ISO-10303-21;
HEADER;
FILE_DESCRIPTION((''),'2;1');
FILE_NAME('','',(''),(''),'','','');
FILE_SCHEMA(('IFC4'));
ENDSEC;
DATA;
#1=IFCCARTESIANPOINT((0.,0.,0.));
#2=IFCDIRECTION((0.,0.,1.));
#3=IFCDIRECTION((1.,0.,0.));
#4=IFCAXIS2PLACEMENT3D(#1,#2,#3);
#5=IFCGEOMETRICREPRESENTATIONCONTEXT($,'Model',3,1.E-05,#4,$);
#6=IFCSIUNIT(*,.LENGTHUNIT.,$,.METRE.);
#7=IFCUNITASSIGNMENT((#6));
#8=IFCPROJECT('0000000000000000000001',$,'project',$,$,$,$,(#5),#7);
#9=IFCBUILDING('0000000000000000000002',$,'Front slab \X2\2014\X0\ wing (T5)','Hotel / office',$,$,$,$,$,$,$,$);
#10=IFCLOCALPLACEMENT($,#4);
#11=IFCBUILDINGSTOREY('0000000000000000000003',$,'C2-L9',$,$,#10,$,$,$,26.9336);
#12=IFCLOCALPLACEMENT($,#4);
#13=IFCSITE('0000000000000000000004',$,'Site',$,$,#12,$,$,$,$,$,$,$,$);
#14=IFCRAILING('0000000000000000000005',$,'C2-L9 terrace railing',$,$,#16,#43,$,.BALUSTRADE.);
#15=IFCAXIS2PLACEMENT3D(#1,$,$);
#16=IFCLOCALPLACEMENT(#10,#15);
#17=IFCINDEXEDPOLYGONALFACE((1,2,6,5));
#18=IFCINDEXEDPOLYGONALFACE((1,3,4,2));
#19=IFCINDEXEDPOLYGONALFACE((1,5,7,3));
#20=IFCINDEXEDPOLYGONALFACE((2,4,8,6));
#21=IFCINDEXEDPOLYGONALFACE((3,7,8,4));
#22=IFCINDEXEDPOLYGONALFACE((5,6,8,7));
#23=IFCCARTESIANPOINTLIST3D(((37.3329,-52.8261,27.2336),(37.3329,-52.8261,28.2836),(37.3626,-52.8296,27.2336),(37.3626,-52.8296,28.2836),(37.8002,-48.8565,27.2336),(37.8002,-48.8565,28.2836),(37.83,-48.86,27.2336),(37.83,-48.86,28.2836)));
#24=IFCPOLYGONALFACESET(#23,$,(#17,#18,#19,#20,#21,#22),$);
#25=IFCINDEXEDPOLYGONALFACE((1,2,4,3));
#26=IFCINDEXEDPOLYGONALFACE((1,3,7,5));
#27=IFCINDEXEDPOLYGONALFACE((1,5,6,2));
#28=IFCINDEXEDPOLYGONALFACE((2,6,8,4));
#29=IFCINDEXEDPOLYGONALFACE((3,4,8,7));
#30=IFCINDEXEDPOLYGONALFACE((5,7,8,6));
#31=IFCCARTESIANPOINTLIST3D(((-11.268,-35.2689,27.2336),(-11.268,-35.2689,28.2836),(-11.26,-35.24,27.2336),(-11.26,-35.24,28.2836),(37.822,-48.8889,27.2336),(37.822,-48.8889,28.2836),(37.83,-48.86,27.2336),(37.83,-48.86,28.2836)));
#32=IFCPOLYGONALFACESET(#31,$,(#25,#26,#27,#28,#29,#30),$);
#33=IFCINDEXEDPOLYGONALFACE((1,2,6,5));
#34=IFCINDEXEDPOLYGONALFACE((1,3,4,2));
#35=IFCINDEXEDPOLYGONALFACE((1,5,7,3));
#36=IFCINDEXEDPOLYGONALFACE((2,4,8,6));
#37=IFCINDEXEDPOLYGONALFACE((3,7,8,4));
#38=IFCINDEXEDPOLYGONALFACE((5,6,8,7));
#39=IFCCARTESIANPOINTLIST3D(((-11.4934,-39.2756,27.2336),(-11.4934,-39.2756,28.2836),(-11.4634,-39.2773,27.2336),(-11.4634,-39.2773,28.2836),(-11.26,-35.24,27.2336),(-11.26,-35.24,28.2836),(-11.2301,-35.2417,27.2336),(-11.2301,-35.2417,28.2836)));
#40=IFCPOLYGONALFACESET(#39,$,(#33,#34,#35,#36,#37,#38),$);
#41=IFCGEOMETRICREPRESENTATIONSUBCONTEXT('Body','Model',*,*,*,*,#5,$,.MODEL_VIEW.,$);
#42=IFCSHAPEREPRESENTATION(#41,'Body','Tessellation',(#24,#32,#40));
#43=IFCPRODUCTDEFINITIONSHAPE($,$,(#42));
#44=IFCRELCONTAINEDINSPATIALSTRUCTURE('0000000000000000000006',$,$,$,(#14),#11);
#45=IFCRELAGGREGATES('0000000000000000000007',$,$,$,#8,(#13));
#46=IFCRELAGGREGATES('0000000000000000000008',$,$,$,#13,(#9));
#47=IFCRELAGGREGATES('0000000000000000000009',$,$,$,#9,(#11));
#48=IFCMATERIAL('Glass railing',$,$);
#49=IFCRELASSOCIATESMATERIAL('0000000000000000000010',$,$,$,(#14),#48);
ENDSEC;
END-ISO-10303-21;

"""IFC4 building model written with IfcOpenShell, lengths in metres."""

from ifc_helpers import new_model, si_unit, frame, origin_with_axes, place, context, subcontext, project, spatial, polyline, outline, extrude, material, element, save


model = new_model("IFC4")

# Units and contexts
model_context = context("Model", 3, precision=1e-05, world=origin_with_axes())
body_context = subcontext(model_context, "Body", "Model", "MODEL_VIEW")
ifc_project = project(units=[si_unit("LENGTHUNIT", "METRE")], contexts=[model_context])

# Site, building, storey
site_placement = place(None, origin_with_axes())
site = spatial("IfcSite", under=ifc_project, at=site_placement, Name="Site")
building = spatial("IfcBuilding", under=site, Name="Front slab — wing (T5)", Description="Hotel / office")
storey_placement = place(None, origin_with_axes())
storey = spatial("IfcBuildingStorey", under=building, at=storey_placement, Name="C2-L9", Elevation=26.9336)

# Railing
ifc_material = material(Name="Glass railing")
railing_placement = place(storey_placement, origin_with_axes())
element("IfcRailing", 1, at=railing_placement, inside=storey, material=ifc_material, Name="C2-L9 terrace railing", PredefinedType="BALUSTRADE", context=body_context, shape_type="SweptSolid", body=[
    extrude(outline(polyline([(37.3626, -52.8296), (37.83, -48.86), (37.8002, -48.8565), (37.3329, -52.8261), (37.3626, -52.8296)])), frame((0.0, 0.0, 27.2336), z_axis=(0.0, 0.0, 1.0), x_axis=(1.0, 0.0, 0.0)), (0.0, 0.0, 1.0), 1.05),
    extrude(outline(polyline([(37.83, -48.86), (-11.26, -35.24), (-11.268, -35.2689), (37.822, -48.8889), (37.83, -48.86)])), frame((0.0, 0.0, 27.2336), z_axis=(0.0, 0.0, 1.0), x_axis=(1.0, 0.0, 0.0)), (0.0, 0.0, 1.0), 1.05),
    extrude(outline(polyline([(-11.26, -35.24), (-11.4934, -39.2756), (-11.4634, -39.2773), (-11.2301, -35.2417), (-11.26, -35.24)])), frame((0.0, 0.0, 27.2336), z_axis=(0.0, 0.0, 1.0), x_axis=(1.0, 0.0, 0.0)), (0.0, 0.0, 1.0), 1.05),
])

save(model, "model.ifc")
